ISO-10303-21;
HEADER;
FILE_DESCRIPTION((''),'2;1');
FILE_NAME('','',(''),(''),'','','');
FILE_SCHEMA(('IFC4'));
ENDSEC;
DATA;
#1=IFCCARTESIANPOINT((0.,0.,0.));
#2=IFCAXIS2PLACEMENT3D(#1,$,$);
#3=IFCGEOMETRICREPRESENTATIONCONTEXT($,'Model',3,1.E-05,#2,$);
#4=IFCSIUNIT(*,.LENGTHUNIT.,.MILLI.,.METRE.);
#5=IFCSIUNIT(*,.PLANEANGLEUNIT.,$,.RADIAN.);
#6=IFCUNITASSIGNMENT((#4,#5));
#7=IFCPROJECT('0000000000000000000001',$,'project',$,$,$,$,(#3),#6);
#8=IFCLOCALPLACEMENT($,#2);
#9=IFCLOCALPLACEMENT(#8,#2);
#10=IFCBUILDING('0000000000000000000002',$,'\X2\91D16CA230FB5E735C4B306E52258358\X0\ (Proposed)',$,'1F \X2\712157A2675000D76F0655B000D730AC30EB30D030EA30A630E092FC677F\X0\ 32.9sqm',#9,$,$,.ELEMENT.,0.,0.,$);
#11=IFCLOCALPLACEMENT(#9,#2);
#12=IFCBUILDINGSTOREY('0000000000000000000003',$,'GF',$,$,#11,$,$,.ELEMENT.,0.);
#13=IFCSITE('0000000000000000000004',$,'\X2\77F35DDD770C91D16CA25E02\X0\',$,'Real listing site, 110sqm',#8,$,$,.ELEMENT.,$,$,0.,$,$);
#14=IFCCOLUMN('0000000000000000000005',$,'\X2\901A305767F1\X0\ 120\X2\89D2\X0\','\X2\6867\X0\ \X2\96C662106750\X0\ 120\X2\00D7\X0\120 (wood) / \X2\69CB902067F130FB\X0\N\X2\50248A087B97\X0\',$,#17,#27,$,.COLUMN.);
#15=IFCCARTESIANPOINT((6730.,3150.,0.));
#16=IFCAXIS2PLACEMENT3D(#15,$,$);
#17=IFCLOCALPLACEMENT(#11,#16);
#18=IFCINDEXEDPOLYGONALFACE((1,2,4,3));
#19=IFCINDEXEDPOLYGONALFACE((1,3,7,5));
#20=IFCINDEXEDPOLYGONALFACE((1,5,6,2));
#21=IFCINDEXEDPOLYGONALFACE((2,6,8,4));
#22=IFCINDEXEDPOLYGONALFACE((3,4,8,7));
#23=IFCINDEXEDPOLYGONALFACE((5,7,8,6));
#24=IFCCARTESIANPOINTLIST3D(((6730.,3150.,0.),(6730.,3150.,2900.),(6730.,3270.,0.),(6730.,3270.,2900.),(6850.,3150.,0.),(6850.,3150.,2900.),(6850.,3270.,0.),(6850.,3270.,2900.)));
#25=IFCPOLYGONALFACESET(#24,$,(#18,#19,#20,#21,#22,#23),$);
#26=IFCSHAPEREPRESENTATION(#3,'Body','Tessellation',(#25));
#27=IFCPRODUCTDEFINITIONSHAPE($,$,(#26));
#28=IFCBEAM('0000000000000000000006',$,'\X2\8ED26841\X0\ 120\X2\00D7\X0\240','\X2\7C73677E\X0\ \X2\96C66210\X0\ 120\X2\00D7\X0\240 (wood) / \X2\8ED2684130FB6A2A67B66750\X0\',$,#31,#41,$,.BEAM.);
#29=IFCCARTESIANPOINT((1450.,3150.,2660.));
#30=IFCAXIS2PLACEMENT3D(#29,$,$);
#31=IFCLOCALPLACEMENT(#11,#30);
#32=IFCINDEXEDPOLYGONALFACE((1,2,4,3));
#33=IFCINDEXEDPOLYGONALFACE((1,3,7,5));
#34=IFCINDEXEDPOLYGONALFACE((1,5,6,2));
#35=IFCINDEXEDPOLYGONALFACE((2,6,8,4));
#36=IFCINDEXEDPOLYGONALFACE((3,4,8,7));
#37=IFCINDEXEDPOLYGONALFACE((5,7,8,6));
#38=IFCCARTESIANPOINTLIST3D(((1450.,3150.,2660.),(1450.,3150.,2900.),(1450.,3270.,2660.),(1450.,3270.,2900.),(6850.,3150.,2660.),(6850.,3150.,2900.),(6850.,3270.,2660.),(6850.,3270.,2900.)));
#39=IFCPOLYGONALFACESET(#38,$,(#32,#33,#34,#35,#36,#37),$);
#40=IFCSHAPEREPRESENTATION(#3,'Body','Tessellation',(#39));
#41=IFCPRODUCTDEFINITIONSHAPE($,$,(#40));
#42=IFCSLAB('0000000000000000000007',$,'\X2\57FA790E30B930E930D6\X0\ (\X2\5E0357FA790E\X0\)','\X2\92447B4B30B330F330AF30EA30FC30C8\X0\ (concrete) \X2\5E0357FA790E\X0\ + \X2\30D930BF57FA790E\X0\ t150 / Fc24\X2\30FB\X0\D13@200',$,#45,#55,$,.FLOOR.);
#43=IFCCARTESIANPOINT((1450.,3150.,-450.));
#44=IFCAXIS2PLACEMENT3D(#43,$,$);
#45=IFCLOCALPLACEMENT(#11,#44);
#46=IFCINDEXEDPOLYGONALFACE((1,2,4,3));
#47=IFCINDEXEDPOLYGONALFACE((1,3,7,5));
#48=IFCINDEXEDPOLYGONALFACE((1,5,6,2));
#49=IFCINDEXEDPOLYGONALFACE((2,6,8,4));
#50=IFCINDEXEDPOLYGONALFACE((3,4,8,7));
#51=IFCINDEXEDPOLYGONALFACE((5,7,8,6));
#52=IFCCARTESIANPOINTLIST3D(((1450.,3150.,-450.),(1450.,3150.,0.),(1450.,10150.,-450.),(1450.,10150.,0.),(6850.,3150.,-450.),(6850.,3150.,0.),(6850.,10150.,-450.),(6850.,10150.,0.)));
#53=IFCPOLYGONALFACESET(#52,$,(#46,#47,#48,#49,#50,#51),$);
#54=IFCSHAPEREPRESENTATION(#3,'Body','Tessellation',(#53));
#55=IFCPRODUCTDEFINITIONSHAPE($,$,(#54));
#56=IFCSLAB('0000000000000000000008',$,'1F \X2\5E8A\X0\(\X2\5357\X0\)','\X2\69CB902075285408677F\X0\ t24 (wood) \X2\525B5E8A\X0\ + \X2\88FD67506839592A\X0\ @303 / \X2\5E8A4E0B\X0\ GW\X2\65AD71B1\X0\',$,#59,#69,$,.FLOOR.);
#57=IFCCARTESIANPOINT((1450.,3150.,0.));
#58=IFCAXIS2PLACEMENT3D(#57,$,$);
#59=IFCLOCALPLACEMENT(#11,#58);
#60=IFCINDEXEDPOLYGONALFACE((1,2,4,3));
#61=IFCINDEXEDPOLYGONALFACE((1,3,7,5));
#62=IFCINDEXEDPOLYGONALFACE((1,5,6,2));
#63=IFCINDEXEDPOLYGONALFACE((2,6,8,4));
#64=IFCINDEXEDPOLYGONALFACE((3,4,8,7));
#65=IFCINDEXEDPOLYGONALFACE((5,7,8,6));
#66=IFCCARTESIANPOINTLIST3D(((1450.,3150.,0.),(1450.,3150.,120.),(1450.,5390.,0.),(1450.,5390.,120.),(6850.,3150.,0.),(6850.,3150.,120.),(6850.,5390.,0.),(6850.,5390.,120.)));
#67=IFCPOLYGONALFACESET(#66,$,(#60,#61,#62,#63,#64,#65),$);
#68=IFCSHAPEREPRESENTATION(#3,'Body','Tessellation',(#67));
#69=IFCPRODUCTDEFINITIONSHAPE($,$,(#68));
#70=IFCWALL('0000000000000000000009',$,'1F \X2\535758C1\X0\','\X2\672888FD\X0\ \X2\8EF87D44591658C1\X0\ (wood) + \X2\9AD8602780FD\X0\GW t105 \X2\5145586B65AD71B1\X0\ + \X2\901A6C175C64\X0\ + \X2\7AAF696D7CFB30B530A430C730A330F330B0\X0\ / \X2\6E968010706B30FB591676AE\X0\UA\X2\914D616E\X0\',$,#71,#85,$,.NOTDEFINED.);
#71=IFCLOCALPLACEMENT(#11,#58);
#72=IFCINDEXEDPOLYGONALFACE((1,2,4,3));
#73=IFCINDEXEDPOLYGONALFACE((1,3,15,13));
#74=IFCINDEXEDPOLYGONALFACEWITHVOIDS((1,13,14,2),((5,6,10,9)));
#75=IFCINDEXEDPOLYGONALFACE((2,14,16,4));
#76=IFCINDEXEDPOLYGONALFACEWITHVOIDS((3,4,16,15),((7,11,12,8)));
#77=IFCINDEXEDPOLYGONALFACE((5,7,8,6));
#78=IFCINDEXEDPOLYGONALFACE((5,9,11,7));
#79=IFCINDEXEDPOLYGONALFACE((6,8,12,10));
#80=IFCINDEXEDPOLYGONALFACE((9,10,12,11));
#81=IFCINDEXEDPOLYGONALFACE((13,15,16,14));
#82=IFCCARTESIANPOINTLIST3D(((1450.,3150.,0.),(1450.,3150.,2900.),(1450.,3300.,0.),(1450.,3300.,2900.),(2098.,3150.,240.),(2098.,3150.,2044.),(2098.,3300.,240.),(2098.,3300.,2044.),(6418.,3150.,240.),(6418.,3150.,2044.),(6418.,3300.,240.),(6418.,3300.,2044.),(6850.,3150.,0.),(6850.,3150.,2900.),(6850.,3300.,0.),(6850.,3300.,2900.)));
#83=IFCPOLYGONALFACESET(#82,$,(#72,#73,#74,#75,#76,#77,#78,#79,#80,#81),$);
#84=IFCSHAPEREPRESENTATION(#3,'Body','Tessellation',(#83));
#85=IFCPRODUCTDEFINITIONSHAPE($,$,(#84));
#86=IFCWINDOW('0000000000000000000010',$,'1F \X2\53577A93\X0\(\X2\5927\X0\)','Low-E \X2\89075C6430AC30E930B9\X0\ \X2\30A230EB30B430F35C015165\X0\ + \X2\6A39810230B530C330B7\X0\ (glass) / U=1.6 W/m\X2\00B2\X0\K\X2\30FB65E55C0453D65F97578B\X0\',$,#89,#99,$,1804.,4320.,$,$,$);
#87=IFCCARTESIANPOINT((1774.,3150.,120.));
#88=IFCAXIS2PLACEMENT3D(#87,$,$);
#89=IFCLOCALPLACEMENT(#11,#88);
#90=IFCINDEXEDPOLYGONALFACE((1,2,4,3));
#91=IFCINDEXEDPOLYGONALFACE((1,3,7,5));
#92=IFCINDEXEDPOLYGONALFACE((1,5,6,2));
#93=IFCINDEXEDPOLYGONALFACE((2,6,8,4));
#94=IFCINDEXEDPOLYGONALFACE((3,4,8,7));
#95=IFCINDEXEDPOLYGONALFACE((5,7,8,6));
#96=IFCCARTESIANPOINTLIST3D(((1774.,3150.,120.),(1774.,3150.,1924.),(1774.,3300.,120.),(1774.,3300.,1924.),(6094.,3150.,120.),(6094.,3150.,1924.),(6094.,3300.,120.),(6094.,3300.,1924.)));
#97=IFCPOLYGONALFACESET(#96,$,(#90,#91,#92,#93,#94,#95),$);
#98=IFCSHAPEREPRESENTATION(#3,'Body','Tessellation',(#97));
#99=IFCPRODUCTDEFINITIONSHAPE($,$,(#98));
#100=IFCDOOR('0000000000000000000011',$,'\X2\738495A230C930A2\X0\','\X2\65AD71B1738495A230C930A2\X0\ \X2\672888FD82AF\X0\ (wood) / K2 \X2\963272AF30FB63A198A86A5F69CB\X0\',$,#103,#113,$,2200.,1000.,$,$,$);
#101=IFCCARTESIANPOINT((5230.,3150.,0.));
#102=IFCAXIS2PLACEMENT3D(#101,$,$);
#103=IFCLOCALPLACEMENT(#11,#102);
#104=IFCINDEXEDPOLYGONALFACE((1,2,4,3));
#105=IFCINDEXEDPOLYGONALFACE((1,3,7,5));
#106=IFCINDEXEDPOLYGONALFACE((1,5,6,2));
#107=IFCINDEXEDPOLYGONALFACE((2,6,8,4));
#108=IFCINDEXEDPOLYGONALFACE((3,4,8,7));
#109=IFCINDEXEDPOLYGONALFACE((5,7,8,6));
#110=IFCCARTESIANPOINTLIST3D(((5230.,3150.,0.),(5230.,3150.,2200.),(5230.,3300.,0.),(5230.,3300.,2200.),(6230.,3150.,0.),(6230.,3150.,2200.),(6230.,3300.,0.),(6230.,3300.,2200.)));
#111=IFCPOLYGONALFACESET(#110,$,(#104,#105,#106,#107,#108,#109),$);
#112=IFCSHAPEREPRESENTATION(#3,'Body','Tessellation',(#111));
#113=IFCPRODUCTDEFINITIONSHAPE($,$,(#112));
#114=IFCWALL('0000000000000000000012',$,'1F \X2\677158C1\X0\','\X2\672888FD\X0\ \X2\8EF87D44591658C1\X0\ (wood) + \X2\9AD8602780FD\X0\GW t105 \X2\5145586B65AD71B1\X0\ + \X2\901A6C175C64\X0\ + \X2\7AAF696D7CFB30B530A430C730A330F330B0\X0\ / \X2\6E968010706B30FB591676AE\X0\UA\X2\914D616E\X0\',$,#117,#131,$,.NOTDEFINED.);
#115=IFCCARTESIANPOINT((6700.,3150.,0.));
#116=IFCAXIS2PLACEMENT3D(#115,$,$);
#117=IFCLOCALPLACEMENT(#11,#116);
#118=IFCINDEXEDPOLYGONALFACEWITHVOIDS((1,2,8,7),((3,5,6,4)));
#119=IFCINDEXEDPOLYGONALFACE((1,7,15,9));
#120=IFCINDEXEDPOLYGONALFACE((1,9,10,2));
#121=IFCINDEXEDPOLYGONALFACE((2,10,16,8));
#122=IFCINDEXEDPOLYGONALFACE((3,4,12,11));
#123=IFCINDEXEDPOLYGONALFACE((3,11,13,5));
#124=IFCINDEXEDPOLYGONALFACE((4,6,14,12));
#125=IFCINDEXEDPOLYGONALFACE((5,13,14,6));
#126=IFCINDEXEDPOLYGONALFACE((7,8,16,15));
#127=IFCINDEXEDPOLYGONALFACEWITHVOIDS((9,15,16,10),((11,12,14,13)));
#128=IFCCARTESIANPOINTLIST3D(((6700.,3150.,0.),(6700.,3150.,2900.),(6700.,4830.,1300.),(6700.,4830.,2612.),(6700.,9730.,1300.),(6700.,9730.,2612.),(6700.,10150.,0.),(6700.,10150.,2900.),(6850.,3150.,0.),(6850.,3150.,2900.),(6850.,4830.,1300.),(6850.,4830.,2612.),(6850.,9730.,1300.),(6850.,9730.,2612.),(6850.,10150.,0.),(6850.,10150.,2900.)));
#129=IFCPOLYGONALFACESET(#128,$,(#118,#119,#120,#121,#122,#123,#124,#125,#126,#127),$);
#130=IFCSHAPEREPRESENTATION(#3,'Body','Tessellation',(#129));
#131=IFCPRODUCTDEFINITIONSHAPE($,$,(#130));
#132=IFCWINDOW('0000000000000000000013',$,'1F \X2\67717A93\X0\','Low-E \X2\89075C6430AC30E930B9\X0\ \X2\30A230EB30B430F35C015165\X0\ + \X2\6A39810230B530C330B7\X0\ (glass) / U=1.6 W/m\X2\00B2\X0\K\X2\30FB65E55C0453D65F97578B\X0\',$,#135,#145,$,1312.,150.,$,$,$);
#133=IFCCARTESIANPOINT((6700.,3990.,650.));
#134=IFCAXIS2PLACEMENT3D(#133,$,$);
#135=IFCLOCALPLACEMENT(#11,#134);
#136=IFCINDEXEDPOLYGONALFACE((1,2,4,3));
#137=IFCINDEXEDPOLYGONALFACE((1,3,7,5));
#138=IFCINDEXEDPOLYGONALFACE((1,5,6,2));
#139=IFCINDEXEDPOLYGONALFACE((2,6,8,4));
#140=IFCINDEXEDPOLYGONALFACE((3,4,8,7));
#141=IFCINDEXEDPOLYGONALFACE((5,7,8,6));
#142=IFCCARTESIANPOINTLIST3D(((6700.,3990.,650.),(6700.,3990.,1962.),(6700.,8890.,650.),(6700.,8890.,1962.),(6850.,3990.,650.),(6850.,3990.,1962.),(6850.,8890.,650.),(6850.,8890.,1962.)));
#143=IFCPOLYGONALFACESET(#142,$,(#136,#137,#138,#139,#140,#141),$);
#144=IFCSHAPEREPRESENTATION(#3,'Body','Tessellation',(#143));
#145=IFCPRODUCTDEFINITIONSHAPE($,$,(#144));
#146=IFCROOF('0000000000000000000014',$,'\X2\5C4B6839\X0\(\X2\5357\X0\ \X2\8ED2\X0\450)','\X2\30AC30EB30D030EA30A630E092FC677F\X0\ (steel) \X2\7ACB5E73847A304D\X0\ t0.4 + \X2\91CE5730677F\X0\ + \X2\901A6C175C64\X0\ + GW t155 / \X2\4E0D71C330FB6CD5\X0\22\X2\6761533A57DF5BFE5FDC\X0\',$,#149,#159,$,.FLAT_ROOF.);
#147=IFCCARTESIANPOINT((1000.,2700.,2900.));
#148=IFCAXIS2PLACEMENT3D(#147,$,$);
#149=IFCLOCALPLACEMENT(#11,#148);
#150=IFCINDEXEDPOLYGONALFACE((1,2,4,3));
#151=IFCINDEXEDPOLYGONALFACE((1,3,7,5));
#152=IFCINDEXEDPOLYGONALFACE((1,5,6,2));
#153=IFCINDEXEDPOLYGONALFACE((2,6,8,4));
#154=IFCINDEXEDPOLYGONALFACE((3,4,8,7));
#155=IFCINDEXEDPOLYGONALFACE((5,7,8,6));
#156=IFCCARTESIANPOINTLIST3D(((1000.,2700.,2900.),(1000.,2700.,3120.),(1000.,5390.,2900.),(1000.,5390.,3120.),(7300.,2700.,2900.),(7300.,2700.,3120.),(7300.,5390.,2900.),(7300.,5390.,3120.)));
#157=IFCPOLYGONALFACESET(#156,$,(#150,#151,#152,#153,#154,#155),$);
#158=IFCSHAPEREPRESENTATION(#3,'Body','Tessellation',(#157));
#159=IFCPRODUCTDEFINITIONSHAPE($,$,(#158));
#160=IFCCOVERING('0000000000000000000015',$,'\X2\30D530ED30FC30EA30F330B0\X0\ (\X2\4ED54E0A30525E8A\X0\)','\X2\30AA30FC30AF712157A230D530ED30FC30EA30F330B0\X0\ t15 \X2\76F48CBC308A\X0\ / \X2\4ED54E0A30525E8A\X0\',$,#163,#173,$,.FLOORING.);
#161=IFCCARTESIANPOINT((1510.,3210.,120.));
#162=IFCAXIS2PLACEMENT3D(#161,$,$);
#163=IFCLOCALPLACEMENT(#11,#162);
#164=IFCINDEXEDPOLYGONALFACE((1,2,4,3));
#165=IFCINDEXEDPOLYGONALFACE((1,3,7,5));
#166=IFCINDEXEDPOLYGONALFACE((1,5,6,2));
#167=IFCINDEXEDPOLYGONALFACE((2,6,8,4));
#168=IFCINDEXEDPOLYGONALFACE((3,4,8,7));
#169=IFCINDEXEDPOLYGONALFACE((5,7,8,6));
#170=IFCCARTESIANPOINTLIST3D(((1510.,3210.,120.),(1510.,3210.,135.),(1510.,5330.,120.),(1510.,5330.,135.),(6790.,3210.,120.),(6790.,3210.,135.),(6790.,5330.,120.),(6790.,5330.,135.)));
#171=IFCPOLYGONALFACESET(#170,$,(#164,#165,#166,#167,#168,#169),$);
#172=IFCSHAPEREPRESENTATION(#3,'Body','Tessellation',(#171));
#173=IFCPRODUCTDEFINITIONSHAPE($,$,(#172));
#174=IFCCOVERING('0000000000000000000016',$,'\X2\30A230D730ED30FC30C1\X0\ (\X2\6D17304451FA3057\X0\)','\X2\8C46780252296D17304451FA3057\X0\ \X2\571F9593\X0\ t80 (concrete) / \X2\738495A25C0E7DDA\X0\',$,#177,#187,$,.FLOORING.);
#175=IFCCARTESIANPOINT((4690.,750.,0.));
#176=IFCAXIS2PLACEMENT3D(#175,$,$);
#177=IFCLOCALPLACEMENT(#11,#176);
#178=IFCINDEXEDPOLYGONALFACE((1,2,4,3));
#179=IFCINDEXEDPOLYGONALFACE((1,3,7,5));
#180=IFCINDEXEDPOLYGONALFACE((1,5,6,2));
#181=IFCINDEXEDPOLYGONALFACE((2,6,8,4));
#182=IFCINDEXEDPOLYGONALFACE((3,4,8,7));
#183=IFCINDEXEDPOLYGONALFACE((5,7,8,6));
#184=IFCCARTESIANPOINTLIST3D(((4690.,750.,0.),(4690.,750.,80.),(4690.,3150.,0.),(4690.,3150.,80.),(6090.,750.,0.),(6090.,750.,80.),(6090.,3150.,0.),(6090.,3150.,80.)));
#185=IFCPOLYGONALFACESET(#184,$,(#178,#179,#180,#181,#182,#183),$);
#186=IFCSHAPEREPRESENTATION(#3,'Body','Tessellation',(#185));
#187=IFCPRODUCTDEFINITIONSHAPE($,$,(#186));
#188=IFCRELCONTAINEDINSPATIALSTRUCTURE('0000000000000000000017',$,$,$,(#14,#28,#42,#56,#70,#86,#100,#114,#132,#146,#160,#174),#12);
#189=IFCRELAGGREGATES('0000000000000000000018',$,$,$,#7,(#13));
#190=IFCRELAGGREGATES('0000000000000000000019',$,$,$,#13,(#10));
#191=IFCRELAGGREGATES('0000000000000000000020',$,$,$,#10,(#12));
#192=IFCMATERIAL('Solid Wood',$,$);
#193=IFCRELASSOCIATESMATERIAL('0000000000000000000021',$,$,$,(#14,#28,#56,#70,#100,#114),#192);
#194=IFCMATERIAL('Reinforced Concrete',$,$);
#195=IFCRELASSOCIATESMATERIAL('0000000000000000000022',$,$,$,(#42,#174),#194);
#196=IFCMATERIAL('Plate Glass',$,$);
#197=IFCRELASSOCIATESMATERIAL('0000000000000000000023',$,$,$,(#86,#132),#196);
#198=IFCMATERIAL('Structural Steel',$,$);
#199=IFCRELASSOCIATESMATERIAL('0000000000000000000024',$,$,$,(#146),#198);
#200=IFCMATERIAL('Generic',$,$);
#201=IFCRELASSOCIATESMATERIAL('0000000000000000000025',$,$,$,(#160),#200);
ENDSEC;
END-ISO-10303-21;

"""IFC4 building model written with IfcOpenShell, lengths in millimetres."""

from ifc_helpers import new_model, si_unit, frame, frame_2d, origin, place, context, project, spatial, rectangle, extrude, material, element, fill, save


model = new_model("IFC4")

# Units and contexts
model_context = context("Model", 3, precision=1e-05, world=origin())
ifc_project = project(units=[si_unit("LENGTHUNIT", "METRE", prefix="MILLI"), si_unit("PLANEANGLEUNIT", "RADIAN")], contexts=[model_context])

# Site, building, storey
site_placement = place(None, origin())
site = spatial("IfcSite", under=ifc_project, at=site_placement, Name="石川県金沢市", ObjectType="Real listing site, 110sqm", CompositionType="ELEMENT", RefElevation=0.0)
building_placement = place(site_placement, origin())
building = spatial("IfcBuilding", under=site, at=building_placement, Name="金沢・平屋の別荘 (Proposed)", ObjectType="1F 無垢材×漆喰×ガルバリウム鋼板 32.9sqm", CompositionType="ELEMENT", ElevationOfRefHeight=0.0, ElevationOfTerrain=0.0)
storey_placement = place(building_placement, origin())
storey = spatial("IfcBuildingStorey", under=building, at=storey_placement, Name="GF", CompositionType="ELEMENT", Elevation=0.0)

# Column
ifc_material_1 = material(Name="Solid Wood")
column_1_placement = place(storey_placement, frame((6730.0, 3150.0, 0.0)))
element("IfcColumn", 1, at=column_1_placement, inside=storey, material=ifc_material_1, Name="通し柱 120角", Description="桧 集成材 120×120 (wood) / 構造柱・N値計算", PredefinedType="COLUMN", context=model_context, shape_type="SweptSolid", body=[
    extrude(rectangle(XDim=120.0, YDim=120.0, at=frame_2d((60.0, 60.0))), frame((6730.0, 3150.0, 0.0)), (0.0, 0.0, 1.0), 2900.0),
])

# Beam
beam_1_placement = place(storey_placement, frame((1450.0, 3150.0, 2660.0)))
element("IfcBeam", 2, at=beam_1_placement, inside=storey, material=ifc_material_1, Name="軒桁 120×240", Description="米松 集成 120×240 (wood) / 軒桁・横架材", PredefinedType="BEAM", context=model_context, shape_type="SweptSolid", body=[
    extrude(rectangle(XDim=5400.0, YDim=120.0, at=frame_2d((2700.0, 60.0))), frame((1450.0, 3150.0, 2660.0)), (0.0, 0.0, 1.0), 240.0),
])

# Slabs
ifc_material_2 = material(Name="Reinforced Concrete")
slab_1_placement = place(storey_placement, frame((1450.0, 3150.0, -450.0)))
element("IfcSlab", 3, at=slab_1_placement, inside=storey, material=ifc_material_2, Name="基礎スラブ (布基礎)", Description="鉄筋コンクリート (concrete) 布基礎 + ベタ基礎 t150 / Fc24・D13@200", PredefinedType="FLOOR", context=model_context, shape_type="SweptSolid", body=[
    extrude(rectangle(XDim=5400.0, YDim=7000.0, at=frame_2d((2700.0, 3500.0))), frame((1450.0, 3150.0, -450.0)), (0.0, 0.0, 1.0), 450.0),
])
slab_2_placement = place(storey_placement, frame((1450.0, 3150.0, 0.0)))
element("IfcSlab", 4, at=slab_2_placement, inside=storey, material=ifc_material_1, Name="1F 床(南)", Description="構造用合板 t24 (wood) 剛床 + 製材根太 @303 / 床下 GW断熱", PredefinedType="FLOOR", context=model_context, shape_type="SweptSolid", body=[
    extrude(rectangle(XDim=5400.0, YDim=2240.0, at=frame_2d((2700.0, 1120.0))), frame((1450.0, 3150.0, 0.0)), (0.0, 0.0, 1.0), 120.0),
])

# Wall, openings, window, door
wall_1_placement = place(storey_placement, frame((1450.0, 3150.0, 0.0)))
wall_1 = element("IfcWall", 5, at=wall_1_placement, inside=storey, material=ifc_material_1, Name="1F 南壁", Description="木製 軸組外壁 (wood) + 高性能GW t105 充填断熱 + 通気層 + 窯業系サイディング / 準耐火・外皮UA配慮", PredefinedType="NOTDEFINED", context=model_context, shape_type="SweptSolid", body=[
    extrude(rectangle(XDim=5400.0, YDim=150.0, at=frame_2d((2700.0, 75.0))), frame((1450.0, 3150.0, 0.0)), (0.0, 0.0, 1.0), 2900.0),
])
opening_1_placement = place(storey_placement, frame((1774.0, 3150.0, 120.0)))
opening_1 = element("IfcOpeningElement", 6, at=opening_1_placement, cuts=wall_1, PredefinedType="NOTDEFINED", context=model_context, shape_type="SweptSolid", body=[
    extrude(rectangle(XDim=4320.0, YDim=150.0, at=frame_2d((2160.0, 75.0))), frame((1774.0, 3150.0, 120.0)), (0.0, 0.0, 1.0), 1804.0),
])
opening_2_placement = place(storey_placement, frame((5230.0, 3150.0, 0.0)))
opening_2 = element("IfcOpeningElement", 7, at=opening_2_placement, cuts=wall_1, PredefinedType="NOTDEFINED", context=model_context, shape_type="SweptSolid", body=[
    extrude(rectangle(XDim=1000.0, YDim=150.0, at=frame_2d((500.0, 75.0))), frame((5230.0, 3150.0, 0.0)), (0.0, 0.0, 1.0), 2200.0),
])
ifc_material_3 = material(Name="Plate Glass")
window_1_placement = place(storey_placement, frame((1774.0, 3150.0, 120.0)))
window_1 = element("IfcWindow", 8, at=window_1_placement, inside=storey, material=ifc_material_3, Name="1F 南窓(大)", Description="Low-E 複層ガラス アルゴン封入 + 樹脂サッシ (glass) / U=1.6 W/m²K・日射取得型", OverallHeight=1804.0, OverallWidth=4320.0, context=model_context, shape_type="SweptSolid", body=[
    extrude(rectangle(XDim=4320.0, YDim=150.0, at=frame_2d((2160.0, 75.0))), frame((1774.0, 3150.0, 120.0)), (0.0, 0.0, 1.0), 1804.0),
])
fill(opening_1, window_1)
door_placement = place(storey_placement, frame((5230.0, 3150.0, 0.0)))
door = element("IfcDoor", 9, at=door_placement, inside=storey, material=ifc_material_1, Name="玄関ドア", Description="断熱玄関ドア 木製芯 (wood) / K2 防犯・採風機構", OverallHeight=2200.0, OverallWidth=1000.0, context=model_context, shape_type="SweptSolid", body=[
    extrude(rectangle(XDim=1000.0, YDim=150.0, at=frame_2d((500.0, 75.0))), frame((5230.0, 3150.0, 0.0)), (0.0, 0.0, 1.0), 2200.0),
])
fill(opening_2, door)

# Wall, opening, window
wall_2_placement = place(storey_placement, frame((6700.0, 3150.0, 0.0)))
wall_2 = element("IfcWall", 10, at=wall_2_placement, inside=storey, material=ifc_material_1, Name="1F 東壁", Description="木製 軸組外壁 (wood) + 高性能GW t105 充填断熱 + 通気層 + 窯業系サイディング / 準耐火・外皮UA配慮", PredefinedType="NOTDEFINED", context=model_context, shape_type="SweptSolid", body=[
    extrude(rectangle(XDim=150.0, YDim=7000.0, at=frame_2d((75.0, 3500.0))), frame((6700.0, 3150.0, 0.0)), (0.0, 0.0, 1.0), 2900.0),
])
opening_3_placement = place(storey_placement, frame((6700.0, 3990.0, 650.0)))
opening_3 = element("IfcOpeningElement", 11, at=opening_3_placement, cuts=wall_2, PredefinedType="NOTDEFINED", context=model_context, shape_type="SweptSolid", body=[
    extrude(rectangle(XDim=150.0, YDim=4900.0, at=frame_2d((75.0, 2450.0))), frame((6700.0, 3990.0, 650.0)), (0.0, 0.0, 1.0), 1312.0),
])
window_2_placement = place(storey_placement, frame((6700.0, 3990.0, 650.0)))
window_2 = element("IfcWindow", 12, at=window_2_placement, inside=storey, material=ifc_material_3, Name="1F 東窓", Description="Low-E 複層ガラス アルゴン封入 + 樹脂サッシ (glass) / U=1.6 W/m²K・日射取得型", OverallHeight=1312.0, OverallWidth=150.0, context=model_context, shape_type="SweptSolid", body=[
    extrude(rectangle(XDim=150.0, YDim=4900.0, at=frame_2d((75.0, 2450.0))), frame((6700.0, 3990.0, 650.0)), (0.0, 0.0, 1.0), 1312.0),
])
fill(opening_3, window_2)

# Roof
ifc_material_4 = material(Name="Structural Steel")
roof_placement = place(storey_placement, frame((1000.0, 2700.0, 2900.0)))
element("IfcRoof", 13, at=roof_placement, inside=storey, material=ifc_material_4, Name="屋根(南 軒450)", Description="ガルバリウム鋼板 (steel) 立平葺き t0.4 + 野地板 + 通気層 + GW t155 / 不燃・法22条区域対応", PredefinedType="FLAT_ROOF", context=model_context, shape_type="SweptSolid", body=[
    extrude(rectangle(XDim=6300.0, YDim=2690.0, at=frame_2d((3150.0, 1345.0))), frame((1000.0, 2700.0, 2900.0)), (0.0, 0.0, 1.0), 220.0),
])

# Coverings
ifc_material_5 = material(Name="Generic")
covering_1_placement = place(storey_placement, frame((1510.0, 3210.0, 120.0)))
element("IfcCovering", 14, at=covering_1_placement, inside=storey, material=ifc_material_5, Name="フローリング (仕上げ床)", Description="オーク無垢フローリング t15 直貼り / 仕上げ床", PredefinedType="FLOORING", context=model_context, shape_type="SweptSolid", body=[
    extrude(rectangle(XDim=5280.0, YDim=2120.0, at=frame_2d((2640.0, 1060.0))), frame((1510.0, 3210.0, 120.0)), (0.0, 0.0, 1.0), 15.0),
])
covering_2_placement = place(storey_placement, frame((4690.0, 750.0, 0.0)))
element("IfcCovering", 15, at=covering_2_placement, inside=storey, material=ifc_material_2, Name="アプローチ (洗い出し)", Description="豆砂利洗い出し 土間 t80 (concrete) / 玄関導線", PredefinedType="FLOORING", context=model_context, shape_type="SweptSolid", body=[
    extrude(rectangle(XDim=1400.0, YDim=2400.0, at=frame_2d((700.0, 1200.0))), frame((4690.0, 750.0, 0.0)), (0.0, 0.0, 1.0), 80.0),
])

save(model, "model.ifc")
